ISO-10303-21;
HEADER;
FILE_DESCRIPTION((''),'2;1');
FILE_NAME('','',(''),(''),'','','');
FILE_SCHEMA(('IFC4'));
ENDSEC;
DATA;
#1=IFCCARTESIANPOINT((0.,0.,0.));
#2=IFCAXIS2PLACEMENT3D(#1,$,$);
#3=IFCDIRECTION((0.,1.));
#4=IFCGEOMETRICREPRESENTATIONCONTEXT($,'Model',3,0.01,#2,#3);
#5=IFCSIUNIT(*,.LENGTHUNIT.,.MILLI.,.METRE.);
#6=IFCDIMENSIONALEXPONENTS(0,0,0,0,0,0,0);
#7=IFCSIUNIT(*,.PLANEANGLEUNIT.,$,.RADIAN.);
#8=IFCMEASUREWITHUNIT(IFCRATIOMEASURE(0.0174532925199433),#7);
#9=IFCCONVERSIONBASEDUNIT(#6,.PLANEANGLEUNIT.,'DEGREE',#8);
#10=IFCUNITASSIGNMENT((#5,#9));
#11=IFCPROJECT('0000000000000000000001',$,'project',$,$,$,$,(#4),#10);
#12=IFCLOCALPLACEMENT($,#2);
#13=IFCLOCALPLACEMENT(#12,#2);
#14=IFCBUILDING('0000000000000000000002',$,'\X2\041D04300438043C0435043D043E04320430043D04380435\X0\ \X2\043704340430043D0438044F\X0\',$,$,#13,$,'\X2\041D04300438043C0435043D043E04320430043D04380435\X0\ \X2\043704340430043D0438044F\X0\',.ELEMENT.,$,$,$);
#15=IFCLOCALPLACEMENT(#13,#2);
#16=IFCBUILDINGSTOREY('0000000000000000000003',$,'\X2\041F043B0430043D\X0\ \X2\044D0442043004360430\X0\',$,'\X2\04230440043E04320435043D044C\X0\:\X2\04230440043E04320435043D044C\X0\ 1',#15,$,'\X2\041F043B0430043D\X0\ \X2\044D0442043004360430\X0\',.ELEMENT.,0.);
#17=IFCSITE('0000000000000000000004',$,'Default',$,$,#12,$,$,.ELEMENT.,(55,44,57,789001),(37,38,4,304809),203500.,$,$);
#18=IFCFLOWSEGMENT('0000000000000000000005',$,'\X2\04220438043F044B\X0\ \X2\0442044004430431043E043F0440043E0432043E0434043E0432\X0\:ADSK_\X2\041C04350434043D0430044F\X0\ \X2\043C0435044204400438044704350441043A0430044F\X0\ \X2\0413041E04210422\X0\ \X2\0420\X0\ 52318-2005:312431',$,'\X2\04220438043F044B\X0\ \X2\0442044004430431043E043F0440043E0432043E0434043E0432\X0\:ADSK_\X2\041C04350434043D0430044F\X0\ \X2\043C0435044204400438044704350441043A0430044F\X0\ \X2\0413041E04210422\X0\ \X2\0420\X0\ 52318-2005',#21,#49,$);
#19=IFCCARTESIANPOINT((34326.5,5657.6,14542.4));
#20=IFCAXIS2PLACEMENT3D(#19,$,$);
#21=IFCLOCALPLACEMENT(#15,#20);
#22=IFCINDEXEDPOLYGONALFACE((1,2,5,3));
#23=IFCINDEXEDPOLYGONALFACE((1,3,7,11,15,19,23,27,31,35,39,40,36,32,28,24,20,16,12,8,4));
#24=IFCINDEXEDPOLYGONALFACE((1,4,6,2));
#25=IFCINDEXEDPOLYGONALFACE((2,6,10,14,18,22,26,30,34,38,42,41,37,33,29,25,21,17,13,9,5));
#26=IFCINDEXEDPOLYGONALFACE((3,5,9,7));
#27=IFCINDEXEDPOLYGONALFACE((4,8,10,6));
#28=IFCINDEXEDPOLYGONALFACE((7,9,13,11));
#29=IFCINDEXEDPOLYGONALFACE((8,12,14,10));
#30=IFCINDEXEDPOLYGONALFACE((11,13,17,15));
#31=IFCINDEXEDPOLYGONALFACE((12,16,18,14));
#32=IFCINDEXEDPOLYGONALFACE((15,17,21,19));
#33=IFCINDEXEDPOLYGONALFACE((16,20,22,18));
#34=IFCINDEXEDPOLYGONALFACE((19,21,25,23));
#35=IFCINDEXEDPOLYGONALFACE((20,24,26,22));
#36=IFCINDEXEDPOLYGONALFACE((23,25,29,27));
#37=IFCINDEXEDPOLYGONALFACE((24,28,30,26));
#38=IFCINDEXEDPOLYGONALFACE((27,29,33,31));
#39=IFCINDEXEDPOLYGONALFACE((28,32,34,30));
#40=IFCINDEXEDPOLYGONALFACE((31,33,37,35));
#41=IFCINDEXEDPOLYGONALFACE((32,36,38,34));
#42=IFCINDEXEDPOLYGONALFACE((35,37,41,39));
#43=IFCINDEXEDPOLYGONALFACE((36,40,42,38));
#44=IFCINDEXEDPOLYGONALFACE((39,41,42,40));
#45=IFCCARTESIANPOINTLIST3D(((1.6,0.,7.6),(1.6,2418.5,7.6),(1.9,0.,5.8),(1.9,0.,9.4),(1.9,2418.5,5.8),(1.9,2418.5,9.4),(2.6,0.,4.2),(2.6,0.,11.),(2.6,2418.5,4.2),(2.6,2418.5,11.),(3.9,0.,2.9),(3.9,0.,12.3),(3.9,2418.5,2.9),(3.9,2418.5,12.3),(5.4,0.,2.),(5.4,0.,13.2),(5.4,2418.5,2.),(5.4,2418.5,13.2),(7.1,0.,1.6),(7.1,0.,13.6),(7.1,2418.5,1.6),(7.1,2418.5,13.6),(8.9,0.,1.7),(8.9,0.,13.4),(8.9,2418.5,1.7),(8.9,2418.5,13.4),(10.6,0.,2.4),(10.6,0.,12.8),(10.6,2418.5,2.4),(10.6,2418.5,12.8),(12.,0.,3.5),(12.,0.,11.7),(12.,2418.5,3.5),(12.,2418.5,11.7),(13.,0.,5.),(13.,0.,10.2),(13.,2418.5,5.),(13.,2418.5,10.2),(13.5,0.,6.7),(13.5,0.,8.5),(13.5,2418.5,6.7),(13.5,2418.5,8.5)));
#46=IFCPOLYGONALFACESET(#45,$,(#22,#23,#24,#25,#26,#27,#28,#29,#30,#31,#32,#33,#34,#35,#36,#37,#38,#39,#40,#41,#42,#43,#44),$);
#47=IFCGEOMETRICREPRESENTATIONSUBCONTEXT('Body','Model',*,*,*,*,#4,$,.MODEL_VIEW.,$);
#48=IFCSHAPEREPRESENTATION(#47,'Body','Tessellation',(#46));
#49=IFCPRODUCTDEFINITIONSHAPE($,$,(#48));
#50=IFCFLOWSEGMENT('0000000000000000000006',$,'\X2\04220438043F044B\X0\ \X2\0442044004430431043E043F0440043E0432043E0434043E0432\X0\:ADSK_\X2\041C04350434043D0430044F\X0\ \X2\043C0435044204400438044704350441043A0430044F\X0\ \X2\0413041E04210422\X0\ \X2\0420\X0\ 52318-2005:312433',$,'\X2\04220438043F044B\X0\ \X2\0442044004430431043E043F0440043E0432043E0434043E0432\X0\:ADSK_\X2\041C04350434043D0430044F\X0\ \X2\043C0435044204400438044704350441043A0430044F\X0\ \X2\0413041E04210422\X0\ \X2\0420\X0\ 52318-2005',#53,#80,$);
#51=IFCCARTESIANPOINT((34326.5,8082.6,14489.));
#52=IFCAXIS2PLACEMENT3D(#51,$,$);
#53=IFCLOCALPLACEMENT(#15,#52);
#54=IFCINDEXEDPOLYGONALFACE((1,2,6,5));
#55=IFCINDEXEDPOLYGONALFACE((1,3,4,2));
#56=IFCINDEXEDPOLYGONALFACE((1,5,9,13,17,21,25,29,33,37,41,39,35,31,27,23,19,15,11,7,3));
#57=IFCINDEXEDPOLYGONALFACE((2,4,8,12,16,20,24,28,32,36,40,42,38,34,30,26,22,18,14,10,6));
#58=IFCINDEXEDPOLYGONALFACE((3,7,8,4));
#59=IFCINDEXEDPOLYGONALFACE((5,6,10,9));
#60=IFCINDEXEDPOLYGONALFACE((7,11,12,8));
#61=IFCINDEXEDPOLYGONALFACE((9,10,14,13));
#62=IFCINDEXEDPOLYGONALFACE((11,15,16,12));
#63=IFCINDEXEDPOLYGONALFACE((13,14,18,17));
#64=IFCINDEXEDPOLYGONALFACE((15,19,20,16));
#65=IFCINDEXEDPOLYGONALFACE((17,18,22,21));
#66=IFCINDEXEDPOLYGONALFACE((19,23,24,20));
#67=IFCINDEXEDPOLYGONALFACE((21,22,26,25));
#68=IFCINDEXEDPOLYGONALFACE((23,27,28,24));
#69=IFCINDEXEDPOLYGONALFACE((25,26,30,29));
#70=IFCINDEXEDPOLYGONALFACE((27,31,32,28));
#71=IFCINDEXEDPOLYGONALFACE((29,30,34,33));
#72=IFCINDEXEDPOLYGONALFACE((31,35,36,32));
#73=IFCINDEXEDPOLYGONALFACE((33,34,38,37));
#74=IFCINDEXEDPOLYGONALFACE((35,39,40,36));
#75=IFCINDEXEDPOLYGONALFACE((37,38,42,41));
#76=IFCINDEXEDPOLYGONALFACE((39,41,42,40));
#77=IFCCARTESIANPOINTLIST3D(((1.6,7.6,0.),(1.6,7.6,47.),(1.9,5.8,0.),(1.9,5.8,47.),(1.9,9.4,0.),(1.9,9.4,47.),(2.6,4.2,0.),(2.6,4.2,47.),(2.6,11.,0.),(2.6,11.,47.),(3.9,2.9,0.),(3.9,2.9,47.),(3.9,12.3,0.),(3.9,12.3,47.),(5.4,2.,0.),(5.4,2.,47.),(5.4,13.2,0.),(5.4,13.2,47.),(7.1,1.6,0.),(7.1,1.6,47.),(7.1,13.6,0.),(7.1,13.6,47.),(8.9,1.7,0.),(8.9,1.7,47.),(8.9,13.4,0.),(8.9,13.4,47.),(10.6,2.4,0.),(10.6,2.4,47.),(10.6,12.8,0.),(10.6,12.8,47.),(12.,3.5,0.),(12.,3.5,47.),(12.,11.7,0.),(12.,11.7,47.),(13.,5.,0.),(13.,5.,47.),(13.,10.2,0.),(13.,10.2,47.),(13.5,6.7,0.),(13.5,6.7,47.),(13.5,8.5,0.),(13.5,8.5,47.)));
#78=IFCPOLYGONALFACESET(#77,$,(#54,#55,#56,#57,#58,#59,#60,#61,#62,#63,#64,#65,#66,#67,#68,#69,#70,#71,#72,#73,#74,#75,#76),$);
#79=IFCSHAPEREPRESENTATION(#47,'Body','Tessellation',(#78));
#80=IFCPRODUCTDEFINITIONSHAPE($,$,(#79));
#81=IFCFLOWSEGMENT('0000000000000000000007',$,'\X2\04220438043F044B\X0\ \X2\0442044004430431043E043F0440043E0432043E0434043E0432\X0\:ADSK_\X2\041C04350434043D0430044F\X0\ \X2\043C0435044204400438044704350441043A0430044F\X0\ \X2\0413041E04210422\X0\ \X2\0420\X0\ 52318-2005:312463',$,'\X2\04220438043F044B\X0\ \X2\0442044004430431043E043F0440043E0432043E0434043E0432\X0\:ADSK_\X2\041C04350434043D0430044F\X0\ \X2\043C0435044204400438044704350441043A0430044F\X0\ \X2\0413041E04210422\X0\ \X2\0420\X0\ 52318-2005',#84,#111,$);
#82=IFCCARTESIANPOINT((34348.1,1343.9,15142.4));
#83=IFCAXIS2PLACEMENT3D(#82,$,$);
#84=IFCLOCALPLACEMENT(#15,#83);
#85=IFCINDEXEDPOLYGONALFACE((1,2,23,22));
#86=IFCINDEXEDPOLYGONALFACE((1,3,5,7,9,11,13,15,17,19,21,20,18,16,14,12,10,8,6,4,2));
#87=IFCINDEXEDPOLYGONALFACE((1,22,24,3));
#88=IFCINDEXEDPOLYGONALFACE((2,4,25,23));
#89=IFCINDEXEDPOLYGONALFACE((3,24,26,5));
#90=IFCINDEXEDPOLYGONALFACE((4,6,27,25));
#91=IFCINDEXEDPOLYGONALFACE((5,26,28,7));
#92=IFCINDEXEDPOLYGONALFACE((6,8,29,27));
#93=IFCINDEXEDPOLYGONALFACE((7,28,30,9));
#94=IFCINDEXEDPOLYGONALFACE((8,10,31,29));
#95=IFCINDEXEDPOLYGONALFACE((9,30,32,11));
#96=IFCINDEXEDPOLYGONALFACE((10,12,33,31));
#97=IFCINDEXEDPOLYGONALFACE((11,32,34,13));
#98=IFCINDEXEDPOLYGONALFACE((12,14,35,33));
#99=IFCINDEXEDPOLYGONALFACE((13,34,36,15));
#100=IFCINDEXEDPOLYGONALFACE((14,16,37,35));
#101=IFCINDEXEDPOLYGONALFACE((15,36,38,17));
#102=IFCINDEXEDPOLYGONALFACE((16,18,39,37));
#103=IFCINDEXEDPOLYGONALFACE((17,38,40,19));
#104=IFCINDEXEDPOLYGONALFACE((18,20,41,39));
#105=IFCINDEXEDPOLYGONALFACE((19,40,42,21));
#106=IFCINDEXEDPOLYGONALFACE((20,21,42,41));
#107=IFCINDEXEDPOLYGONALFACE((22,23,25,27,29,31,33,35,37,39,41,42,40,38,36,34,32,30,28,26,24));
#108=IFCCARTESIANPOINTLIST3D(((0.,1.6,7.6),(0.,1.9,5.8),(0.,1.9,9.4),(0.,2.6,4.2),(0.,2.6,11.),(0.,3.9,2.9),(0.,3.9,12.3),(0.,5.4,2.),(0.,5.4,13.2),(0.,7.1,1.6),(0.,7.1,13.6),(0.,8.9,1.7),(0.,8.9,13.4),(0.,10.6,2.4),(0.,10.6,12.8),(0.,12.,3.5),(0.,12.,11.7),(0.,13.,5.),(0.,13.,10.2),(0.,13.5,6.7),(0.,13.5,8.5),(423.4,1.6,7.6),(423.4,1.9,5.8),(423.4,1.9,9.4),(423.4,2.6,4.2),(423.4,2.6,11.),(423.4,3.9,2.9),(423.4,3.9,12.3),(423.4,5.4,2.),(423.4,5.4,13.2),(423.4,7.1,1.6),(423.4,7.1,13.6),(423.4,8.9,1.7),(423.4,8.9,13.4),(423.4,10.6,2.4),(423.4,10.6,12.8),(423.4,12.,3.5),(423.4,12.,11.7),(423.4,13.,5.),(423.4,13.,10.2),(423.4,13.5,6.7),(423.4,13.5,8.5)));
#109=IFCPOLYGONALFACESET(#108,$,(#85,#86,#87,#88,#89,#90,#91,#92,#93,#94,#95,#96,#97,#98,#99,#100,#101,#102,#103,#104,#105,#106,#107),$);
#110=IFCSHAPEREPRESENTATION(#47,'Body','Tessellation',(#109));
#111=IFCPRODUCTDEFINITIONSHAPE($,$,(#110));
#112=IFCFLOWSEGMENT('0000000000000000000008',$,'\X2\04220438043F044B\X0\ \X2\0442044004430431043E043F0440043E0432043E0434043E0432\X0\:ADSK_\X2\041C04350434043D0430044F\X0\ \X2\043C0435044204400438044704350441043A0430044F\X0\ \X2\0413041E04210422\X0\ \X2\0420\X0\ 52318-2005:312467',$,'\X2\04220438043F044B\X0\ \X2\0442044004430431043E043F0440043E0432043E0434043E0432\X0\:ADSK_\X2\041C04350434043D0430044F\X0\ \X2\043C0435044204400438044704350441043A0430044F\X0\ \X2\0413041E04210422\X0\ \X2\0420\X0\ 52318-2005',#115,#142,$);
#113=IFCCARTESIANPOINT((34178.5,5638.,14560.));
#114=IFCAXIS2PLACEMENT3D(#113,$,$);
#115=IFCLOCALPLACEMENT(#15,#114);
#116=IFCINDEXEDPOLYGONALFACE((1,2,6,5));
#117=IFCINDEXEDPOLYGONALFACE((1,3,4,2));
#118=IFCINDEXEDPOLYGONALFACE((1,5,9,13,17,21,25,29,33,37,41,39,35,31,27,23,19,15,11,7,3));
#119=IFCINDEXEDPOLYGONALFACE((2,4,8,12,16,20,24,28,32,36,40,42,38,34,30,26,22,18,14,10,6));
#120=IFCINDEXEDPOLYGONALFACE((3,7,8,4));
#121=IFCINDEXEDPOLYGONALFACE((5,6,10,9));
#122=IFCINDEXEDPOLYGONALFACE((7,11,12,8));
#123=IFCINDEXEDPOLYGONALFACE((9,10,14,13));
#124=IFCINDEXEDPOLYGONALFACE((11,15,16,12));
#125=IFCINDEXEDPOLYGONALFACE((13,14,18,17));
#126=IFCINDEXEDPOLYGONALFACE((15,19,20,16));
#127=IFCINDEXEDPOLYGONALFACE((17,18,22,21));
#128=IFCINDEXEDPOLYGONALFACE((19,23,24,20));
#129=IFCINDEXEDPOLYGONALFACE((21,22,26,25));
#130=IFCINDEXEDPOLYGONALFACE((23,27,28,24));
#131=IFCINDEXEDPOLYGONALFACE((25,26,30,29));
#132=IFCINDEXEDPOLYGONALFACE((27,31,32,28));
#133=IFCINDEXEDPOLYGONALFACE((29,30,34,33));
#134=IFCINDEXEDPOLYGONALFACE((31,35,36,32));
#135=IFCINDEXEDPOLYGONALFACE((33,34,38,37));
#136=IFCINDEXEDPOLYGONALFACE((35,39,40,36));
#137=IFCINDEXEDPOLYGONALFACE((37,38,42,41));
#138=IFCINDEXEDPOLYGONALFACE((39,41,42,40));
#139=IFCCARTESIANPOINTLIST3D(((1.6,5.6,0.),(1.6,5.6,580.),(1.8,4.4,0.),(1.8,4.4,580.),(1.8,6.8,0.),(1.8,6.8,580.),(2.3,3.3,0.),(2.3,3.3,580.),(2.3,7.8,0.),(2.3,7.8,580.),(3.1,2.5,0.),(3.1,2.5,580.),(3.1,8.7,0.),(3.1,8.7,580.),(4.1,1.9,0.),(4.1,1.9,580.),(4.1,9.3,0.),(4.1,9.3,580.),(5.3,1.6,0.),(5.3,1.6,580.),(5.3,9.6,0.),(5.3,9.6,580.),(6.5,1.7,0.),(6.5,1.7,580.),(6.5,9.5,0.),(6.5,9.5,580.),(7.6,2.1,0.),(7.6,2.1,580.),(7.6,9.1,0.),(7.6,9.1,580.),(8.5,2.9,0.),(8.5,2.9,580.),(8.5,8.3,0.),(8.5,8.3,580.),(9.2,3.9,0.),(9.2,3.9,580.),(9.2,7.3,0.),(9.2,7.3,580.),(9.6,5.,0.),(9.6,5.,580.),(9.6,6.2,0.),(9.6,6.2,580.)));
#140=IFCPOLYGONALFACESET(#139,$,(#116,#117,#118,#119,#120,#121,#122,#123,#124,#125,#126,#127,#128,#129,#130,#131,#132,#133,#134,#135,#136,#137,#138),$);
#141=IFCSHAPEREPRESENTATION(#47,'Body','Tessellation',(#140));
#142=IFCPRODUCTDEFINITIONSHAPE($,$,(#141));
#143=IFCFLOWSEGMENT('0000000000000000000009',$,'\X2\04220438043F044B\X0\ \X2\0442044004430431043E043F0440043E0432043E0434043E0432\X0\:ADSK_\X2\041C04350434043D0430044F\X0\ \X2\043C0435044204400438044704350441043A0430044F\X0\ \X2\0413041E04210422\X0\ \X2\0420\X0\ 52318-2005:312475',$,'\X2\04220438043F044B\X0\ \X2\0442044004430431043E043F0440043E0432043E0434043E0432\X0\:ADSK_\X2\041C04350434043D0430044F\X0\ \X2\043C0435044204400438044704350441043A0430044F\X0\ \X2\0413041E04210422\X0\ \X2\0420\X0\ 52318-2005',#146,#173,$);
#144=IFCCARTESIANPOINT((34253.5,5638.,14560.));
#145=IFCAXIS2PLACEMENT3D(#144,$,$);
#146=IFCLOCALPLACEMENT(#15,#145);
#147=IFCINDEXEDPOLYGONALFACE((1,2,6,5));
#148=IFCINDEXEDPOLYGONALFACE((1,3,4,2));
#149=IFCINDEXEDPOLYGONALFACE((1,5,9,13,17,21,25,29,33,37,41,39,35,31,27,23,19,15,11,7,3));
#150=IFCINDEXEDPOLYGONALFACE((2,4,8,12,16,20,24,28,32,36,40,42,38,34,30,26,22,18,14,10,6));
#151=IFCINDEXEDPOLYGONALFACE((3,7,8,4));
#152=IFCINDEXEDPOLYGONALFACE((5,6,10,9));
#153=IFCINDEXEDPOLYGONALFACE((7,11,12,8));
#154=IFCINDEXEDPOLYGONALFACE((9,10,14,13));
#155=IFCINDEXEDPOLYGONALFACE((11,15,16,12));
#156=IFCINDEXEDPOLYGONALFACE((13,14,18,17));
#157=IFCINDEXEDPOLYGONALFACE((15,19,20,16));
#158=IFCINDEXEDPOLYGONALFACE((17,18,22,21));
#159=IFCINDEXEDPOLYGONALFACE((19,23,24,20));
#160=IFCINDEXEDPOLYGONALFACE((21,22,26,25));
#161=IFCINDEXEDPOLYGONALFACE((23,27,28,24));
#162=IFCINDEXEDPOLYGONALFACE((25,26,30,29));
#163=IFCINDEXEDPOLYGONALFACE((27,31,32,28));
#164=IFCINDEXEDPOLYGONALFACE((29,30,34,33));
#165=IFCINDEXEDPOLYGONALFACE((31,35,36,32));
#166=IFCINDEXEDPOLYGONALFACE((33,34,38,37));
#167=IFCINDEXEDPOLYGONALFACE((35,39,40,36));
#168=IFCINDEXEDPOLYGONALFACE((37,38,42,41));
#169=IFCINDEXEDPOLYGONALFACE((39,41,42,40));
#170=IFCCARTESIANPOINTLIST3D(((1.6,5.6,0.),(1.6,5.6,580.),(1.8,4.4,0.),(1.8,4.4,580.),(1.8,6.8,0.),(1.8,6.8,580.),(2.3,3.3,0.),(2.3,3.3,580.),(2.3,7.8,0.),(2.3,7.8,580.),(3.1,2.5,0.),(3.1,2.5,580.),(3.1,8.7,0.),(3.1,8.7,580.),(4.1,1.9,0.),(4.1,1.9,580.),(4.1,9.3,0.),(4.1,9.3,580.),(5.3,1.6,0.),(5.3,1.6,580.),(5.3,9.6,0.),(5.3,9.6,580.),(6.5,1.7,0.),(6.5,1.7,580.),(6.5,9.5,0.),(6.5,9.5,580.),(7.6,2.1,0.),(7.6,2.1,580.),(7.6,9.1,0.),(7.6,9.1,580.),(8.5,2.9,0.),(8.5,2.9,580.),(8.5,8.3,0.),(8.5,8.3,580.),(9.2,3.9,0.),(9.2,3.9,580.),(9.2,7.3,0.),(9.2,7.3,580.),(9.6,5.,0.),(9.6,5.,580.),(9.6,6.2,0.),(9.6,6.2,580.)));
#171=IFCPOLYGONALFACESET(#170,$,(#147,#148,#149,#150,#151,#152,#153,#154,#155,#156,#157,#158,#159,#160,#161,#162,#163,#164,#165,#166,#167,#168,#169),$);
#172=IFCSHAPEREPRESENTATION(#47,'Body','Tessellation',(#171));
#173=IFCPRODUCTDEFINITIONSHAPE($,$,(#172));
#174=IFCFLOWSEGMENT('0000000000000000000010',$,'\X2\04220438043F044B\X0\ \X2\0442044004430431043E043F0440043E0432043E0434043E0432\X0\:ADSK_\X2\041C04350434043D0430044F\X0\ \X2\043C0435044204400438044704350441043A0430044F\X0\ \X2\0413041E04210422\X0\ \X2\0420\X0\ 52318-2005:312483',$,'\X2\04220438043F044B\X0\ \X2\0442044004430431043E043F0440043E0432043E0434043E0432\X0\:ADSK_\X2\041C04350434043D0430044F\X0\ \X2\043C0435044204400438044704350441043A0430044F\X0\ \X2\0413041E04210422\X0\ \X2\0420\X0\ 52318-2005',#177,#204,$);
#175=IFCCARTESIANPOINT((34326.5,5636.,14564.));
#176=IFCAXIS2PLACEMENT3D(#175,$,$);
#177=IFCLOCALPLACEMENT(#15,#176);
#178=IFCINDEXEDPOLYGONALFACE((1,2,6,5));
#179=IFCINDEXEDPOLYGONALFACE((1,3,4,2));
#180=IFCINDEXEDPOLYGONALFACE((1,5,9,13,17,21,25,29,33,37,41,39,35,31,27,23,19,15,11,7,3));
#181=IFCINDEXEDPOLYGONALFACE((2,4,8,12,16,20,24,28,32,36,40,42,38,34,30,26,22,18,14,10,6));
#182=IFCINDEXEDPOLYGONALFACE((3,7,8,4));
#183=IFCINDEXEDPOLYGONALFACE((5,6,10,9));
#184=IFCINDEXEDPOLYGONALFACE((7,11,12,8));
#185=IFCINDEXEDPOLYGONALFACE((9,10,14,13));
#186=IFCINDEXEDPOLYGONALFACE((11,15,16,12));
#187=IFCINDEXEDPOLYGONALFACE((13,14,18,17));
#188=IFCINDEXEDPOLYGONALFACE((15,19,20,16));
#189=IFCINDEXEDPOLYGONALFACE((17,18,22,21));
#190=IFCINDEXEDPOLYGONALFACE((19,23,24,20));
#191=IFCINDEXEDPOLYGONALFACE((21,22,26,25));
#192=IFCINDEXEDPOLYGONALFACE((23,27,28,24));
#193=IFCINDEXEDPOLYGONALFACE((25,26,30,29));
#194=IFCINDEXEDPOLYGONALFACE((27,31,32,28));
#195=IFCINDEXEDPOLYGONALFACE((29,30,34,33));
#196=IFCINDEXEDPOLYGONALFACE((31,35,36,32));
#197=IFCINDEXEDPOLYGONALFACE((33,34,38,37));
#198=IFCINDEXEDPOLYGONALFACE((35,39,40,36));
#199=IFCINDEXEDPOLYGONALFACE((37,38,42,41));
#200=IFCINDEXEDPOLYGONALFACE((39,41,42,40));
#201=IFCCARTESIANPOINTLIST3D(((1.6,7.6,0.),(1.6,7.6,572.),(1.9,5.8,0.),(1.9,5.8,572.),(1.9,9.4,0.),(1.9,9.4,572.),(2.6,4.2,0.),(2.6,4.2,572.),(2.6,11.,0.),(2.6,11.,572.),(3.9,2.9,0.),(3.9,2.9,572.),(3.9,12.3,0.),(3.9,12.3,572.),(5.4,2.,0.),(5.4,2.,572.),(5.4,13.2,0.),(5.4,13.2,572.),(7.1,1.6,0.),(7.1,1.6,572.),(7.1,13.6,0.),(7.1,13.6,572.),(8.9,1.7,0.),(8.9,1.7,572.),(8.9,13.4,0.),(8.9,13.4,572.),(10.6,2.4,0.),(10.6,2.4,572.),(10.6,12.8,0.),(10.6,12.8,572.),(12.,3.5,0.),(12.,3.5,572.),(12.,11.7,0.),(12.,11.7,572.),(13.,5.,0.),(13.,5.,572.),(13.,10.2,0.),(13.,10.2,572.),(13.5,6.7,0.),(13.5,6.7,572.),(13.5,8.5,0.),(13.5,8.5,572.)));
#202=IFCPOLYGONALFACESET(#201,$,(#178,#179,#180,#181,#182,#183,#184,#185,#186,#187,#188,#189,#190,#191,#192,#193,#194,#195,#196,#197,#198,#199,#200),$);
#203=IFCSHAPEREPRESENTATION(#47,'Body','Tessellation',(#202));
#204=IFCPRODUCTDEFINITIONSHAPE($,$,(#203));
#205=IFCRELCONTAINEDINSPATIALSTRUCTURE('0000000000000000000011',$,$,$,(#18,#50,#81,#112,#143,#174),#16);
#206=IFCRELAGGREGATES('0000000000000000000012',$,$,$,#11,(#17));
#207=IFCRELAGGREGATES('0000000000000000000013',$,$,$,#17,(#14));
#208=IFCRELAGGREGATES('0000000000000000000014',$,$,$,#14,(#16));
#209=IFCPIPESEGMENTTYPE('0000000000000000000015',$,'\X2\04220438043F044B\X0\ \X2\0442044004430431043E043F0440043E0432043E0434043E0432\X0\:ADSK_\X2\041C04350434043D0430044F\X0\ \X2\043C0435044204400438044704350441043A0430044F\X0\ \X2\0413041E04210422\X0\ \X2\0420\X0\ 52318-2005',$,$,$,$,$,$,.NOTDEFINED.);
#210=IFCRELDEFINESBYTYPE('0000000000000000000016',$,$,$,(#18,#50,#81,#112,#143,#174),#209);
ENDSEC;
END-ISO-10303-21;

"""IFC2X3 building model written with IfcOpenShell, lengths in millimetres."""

from ifc_helpers import new_model, entity, si_unit, converted_unit, direction, frame, frame_2d, origin, origin_2d_with_axis, place, context, subcontext, project, spatial, circle, extrude, type_object, element, save


model = new_model("IFC2X3")

# Units and contexts
model_context = context("Model", 3, precision=0.01, world=origin(), true_north=direction((0.0, 1.0)))
body_context = subcontext(model_context, "Body", "Model", "MODEL_VIEW")
ifc_project = project(units=[si_unit("LENGTHUNIT", "METRE", prefix="MILLI"), converted_unit("PLANEANGLEUNIT", "DEGREE", entity("IfcRatioMeasure", 0.0174532925199433), si_unit("PLANEANGLEUNIT", "RADIAN"), dimensions=[0, 0, 0, 0, 0, 0, 0])], contexts=[model_context])

# Site, building, storey
site_placement = place(None, frame((0.0, 0.0, 0.0)))
site = spatial("IfcSite", under=ifc_project, at=site_placement, Name="Default", CompositionType="ELEMENT", RefLatitude=(55, 44, 57, 789001), RefLongitude=(37, 38, 4, 304809), RefElevation=203500.0)
building_placement = place(site_placement, origin())
building = spatial("IfcBuilding", under=site, at=building_placement, Name="Наименование здания", LongName="Наименование здания", CompositionType="ELEMENT")
storey_placement = place(building_placement, origin())
storey = spatial("IfcBuildingStorey", under=building, at=storey_placement, Name="План этажа", ObjectType="Уровень:Уровень 1", LongName="План этажа", CompositionType="ELEMENT", Elevation=0.0)

# Flow segments
pipe_segment_type = type_object("IfcPipeSegmentType", Name="Типы трубопроводов:ADSK_Медная метрическая ГОСТ Р 52318-2005", PredefinedType="NOTDEFINED")
flow_segment_1_placement = place(storey_placement, frame((34326.5, 5657.6, 14542.4)))
element("IfcFlowSegment", 1, at=flow_segment_1_placement, inside=storey, type_object=pipe_segment_type, Name="Типы трубопроводов:ADSK_Медная метрическая ГОСТ Р 52318-2005:312431", ObjectType="Типы трубопроводов:ADSK_Медная метрическая ГОСТ Р 52318-2005", context=body_context, shape_type="SweptSolid", body=[
    extrude(circle(Radius=6.0, at=origin_2d_with_axis()), frame((7.6, 0.0, 7.6), z_axis=(0.0, 1.0, 0.0), x_axis=(-1.0, 0.0, 0.0)), (0.0, 0.0, 1.0), 2418.5),
])
flow_segment_2_placement = place(storey_placement, frame((34326.5, 8082.6, 14489.0)))
element("IfcFlowSegment", 2, at=flow_segment_2_placement, inside=storey, type_object=pipe_segment_type, Name="Типы трубопроводов:ADSK_Медная метрическая ГОСТ Р 52318-2005:312433", ObjectType="Типы трубопроводов:ADSK_Медная метрическая ГОСТ Р 52318-2005", context=body_context, shape_type="SweptSolid", body=[
    extrude(circle(Radius=6.0, at=frame_2d((0.0, 0.0), x_axis=(1.0, 0.0))), frame((7.6, 7.6, 0.0), z_axis=(0.0, 0.0, 1.0), x_axis=(-1.0, 0.0, 0.0)), (0.0, 0.0, 1.0), 47.0),
])
flow_segment_3_placement = place(storey_placement, frame((34348.1, 1343.9, 15142.4)))
element("IfcFlowSegment", 3, at=flow_segment_3_placement, inside=storey, type_object=pipe_segment_type, Name="Типы трубопроводов:ADSK_Медная метрическая ГОСТ Р 52318-2005:312463", ObjectType="Типы трубопроводов:ADSK_Медная метрическая ГОСТ Р 52318-2005", context=body_context, shape_type="SweptSolid", body=[
    extrude(circle(Radius=6.0, at=frame_2d((0.0, 0.0), x_axis=(1.0, 0.0))), frame((0.0, 7.6, 7.6), z_axis=(1.0, 0.0, 0.0), x_axis=(0.0, -1.0, 0.0)), (0.0, 0.0, 1.0), 423.4),
])
flow_segment_4_placement = place(storey_placement, frame((34178.5, 5638.0, 14560.0)))
element("IfcFlowSegment", 4, at=flow_segment_4_placement, inside=storey, type_object=pipe_segment_type, Name="Типы трубопроводов:ADSK_Медная метрическая ГОСТ Р 52318-2005:312467", ObjectType="Типы трубопроводов:ADSK_Медная метрическая ГОСТ Р 52318-2005", context=body_context, shape_type="SweptSolid", body=[
    extrude(circle(Radius=4.0, at=frame_2d((0.0, 0.0), x_axis=(1.0, 0.0))), frame((5.6, 5.6, 0.0), z_axis=(0.0, 0.0, 1.0), x_axis=(-1.0, 0.0, 0.0)), (0.0, 0.0, 1.0), 580.0),
])
flow_segment_5_placement = place(storey_placement, frame((34253.5, 5638.0, 14560.0)))
element("IfcFlowSegment", 5, at=flow_segment_5_placement, inside=storey, type_object=pipe_segment_type, Name="Типы трубопроводов:ADSK_Медная метрическая ГОСТ Р 52318-2005:312475", ObjectType="Типы трубопроводов:ADSK_Медная метрическая ГОСТ Р 52318-2005", context=body_context, shape_type="SweptSolid", body=[
    extrude(circle(Radius=4.0, at=origin_2d_with_axis()), frame((5.6, 5.6, 0.0), z_axis=(0.0, 0.0, 1.0), x_axis=(-1.0, 0.0, 0.0)), (0.0, 0.0, 1.0), 580.0),
])
flow_segment_6_placement = place(storey_placement, frame((34326.5, 5636.0, 14564.0)))
element("IfcFlowSegment", 6, at=flow_segment_6_placement, inside=storey, type_object=pipe_segment_type, Name="Типы трубопроводов:ADSK_Медная метрическая ГОСТ Р 52318-2005:312483", ObjectType="Типы трубопроводов:ADSK_Медная метрическая ГОСТ Р 52318-2005", context=body_context, shape_type="SweptSolid", body=[
    extrude(circle(Radius=6.0, at=frame_2d((0.0, 0.0), x_axis=(1.0, 0.0))), frame((7.6, 7.6, 0.0), z_axis=(0.0, 0.0, 1.0), x_axis=(-1.0, 0.0, 0.0)), (0.0, 0.0, 1.0), 572.0),
])

save(model, "model.ifc")
